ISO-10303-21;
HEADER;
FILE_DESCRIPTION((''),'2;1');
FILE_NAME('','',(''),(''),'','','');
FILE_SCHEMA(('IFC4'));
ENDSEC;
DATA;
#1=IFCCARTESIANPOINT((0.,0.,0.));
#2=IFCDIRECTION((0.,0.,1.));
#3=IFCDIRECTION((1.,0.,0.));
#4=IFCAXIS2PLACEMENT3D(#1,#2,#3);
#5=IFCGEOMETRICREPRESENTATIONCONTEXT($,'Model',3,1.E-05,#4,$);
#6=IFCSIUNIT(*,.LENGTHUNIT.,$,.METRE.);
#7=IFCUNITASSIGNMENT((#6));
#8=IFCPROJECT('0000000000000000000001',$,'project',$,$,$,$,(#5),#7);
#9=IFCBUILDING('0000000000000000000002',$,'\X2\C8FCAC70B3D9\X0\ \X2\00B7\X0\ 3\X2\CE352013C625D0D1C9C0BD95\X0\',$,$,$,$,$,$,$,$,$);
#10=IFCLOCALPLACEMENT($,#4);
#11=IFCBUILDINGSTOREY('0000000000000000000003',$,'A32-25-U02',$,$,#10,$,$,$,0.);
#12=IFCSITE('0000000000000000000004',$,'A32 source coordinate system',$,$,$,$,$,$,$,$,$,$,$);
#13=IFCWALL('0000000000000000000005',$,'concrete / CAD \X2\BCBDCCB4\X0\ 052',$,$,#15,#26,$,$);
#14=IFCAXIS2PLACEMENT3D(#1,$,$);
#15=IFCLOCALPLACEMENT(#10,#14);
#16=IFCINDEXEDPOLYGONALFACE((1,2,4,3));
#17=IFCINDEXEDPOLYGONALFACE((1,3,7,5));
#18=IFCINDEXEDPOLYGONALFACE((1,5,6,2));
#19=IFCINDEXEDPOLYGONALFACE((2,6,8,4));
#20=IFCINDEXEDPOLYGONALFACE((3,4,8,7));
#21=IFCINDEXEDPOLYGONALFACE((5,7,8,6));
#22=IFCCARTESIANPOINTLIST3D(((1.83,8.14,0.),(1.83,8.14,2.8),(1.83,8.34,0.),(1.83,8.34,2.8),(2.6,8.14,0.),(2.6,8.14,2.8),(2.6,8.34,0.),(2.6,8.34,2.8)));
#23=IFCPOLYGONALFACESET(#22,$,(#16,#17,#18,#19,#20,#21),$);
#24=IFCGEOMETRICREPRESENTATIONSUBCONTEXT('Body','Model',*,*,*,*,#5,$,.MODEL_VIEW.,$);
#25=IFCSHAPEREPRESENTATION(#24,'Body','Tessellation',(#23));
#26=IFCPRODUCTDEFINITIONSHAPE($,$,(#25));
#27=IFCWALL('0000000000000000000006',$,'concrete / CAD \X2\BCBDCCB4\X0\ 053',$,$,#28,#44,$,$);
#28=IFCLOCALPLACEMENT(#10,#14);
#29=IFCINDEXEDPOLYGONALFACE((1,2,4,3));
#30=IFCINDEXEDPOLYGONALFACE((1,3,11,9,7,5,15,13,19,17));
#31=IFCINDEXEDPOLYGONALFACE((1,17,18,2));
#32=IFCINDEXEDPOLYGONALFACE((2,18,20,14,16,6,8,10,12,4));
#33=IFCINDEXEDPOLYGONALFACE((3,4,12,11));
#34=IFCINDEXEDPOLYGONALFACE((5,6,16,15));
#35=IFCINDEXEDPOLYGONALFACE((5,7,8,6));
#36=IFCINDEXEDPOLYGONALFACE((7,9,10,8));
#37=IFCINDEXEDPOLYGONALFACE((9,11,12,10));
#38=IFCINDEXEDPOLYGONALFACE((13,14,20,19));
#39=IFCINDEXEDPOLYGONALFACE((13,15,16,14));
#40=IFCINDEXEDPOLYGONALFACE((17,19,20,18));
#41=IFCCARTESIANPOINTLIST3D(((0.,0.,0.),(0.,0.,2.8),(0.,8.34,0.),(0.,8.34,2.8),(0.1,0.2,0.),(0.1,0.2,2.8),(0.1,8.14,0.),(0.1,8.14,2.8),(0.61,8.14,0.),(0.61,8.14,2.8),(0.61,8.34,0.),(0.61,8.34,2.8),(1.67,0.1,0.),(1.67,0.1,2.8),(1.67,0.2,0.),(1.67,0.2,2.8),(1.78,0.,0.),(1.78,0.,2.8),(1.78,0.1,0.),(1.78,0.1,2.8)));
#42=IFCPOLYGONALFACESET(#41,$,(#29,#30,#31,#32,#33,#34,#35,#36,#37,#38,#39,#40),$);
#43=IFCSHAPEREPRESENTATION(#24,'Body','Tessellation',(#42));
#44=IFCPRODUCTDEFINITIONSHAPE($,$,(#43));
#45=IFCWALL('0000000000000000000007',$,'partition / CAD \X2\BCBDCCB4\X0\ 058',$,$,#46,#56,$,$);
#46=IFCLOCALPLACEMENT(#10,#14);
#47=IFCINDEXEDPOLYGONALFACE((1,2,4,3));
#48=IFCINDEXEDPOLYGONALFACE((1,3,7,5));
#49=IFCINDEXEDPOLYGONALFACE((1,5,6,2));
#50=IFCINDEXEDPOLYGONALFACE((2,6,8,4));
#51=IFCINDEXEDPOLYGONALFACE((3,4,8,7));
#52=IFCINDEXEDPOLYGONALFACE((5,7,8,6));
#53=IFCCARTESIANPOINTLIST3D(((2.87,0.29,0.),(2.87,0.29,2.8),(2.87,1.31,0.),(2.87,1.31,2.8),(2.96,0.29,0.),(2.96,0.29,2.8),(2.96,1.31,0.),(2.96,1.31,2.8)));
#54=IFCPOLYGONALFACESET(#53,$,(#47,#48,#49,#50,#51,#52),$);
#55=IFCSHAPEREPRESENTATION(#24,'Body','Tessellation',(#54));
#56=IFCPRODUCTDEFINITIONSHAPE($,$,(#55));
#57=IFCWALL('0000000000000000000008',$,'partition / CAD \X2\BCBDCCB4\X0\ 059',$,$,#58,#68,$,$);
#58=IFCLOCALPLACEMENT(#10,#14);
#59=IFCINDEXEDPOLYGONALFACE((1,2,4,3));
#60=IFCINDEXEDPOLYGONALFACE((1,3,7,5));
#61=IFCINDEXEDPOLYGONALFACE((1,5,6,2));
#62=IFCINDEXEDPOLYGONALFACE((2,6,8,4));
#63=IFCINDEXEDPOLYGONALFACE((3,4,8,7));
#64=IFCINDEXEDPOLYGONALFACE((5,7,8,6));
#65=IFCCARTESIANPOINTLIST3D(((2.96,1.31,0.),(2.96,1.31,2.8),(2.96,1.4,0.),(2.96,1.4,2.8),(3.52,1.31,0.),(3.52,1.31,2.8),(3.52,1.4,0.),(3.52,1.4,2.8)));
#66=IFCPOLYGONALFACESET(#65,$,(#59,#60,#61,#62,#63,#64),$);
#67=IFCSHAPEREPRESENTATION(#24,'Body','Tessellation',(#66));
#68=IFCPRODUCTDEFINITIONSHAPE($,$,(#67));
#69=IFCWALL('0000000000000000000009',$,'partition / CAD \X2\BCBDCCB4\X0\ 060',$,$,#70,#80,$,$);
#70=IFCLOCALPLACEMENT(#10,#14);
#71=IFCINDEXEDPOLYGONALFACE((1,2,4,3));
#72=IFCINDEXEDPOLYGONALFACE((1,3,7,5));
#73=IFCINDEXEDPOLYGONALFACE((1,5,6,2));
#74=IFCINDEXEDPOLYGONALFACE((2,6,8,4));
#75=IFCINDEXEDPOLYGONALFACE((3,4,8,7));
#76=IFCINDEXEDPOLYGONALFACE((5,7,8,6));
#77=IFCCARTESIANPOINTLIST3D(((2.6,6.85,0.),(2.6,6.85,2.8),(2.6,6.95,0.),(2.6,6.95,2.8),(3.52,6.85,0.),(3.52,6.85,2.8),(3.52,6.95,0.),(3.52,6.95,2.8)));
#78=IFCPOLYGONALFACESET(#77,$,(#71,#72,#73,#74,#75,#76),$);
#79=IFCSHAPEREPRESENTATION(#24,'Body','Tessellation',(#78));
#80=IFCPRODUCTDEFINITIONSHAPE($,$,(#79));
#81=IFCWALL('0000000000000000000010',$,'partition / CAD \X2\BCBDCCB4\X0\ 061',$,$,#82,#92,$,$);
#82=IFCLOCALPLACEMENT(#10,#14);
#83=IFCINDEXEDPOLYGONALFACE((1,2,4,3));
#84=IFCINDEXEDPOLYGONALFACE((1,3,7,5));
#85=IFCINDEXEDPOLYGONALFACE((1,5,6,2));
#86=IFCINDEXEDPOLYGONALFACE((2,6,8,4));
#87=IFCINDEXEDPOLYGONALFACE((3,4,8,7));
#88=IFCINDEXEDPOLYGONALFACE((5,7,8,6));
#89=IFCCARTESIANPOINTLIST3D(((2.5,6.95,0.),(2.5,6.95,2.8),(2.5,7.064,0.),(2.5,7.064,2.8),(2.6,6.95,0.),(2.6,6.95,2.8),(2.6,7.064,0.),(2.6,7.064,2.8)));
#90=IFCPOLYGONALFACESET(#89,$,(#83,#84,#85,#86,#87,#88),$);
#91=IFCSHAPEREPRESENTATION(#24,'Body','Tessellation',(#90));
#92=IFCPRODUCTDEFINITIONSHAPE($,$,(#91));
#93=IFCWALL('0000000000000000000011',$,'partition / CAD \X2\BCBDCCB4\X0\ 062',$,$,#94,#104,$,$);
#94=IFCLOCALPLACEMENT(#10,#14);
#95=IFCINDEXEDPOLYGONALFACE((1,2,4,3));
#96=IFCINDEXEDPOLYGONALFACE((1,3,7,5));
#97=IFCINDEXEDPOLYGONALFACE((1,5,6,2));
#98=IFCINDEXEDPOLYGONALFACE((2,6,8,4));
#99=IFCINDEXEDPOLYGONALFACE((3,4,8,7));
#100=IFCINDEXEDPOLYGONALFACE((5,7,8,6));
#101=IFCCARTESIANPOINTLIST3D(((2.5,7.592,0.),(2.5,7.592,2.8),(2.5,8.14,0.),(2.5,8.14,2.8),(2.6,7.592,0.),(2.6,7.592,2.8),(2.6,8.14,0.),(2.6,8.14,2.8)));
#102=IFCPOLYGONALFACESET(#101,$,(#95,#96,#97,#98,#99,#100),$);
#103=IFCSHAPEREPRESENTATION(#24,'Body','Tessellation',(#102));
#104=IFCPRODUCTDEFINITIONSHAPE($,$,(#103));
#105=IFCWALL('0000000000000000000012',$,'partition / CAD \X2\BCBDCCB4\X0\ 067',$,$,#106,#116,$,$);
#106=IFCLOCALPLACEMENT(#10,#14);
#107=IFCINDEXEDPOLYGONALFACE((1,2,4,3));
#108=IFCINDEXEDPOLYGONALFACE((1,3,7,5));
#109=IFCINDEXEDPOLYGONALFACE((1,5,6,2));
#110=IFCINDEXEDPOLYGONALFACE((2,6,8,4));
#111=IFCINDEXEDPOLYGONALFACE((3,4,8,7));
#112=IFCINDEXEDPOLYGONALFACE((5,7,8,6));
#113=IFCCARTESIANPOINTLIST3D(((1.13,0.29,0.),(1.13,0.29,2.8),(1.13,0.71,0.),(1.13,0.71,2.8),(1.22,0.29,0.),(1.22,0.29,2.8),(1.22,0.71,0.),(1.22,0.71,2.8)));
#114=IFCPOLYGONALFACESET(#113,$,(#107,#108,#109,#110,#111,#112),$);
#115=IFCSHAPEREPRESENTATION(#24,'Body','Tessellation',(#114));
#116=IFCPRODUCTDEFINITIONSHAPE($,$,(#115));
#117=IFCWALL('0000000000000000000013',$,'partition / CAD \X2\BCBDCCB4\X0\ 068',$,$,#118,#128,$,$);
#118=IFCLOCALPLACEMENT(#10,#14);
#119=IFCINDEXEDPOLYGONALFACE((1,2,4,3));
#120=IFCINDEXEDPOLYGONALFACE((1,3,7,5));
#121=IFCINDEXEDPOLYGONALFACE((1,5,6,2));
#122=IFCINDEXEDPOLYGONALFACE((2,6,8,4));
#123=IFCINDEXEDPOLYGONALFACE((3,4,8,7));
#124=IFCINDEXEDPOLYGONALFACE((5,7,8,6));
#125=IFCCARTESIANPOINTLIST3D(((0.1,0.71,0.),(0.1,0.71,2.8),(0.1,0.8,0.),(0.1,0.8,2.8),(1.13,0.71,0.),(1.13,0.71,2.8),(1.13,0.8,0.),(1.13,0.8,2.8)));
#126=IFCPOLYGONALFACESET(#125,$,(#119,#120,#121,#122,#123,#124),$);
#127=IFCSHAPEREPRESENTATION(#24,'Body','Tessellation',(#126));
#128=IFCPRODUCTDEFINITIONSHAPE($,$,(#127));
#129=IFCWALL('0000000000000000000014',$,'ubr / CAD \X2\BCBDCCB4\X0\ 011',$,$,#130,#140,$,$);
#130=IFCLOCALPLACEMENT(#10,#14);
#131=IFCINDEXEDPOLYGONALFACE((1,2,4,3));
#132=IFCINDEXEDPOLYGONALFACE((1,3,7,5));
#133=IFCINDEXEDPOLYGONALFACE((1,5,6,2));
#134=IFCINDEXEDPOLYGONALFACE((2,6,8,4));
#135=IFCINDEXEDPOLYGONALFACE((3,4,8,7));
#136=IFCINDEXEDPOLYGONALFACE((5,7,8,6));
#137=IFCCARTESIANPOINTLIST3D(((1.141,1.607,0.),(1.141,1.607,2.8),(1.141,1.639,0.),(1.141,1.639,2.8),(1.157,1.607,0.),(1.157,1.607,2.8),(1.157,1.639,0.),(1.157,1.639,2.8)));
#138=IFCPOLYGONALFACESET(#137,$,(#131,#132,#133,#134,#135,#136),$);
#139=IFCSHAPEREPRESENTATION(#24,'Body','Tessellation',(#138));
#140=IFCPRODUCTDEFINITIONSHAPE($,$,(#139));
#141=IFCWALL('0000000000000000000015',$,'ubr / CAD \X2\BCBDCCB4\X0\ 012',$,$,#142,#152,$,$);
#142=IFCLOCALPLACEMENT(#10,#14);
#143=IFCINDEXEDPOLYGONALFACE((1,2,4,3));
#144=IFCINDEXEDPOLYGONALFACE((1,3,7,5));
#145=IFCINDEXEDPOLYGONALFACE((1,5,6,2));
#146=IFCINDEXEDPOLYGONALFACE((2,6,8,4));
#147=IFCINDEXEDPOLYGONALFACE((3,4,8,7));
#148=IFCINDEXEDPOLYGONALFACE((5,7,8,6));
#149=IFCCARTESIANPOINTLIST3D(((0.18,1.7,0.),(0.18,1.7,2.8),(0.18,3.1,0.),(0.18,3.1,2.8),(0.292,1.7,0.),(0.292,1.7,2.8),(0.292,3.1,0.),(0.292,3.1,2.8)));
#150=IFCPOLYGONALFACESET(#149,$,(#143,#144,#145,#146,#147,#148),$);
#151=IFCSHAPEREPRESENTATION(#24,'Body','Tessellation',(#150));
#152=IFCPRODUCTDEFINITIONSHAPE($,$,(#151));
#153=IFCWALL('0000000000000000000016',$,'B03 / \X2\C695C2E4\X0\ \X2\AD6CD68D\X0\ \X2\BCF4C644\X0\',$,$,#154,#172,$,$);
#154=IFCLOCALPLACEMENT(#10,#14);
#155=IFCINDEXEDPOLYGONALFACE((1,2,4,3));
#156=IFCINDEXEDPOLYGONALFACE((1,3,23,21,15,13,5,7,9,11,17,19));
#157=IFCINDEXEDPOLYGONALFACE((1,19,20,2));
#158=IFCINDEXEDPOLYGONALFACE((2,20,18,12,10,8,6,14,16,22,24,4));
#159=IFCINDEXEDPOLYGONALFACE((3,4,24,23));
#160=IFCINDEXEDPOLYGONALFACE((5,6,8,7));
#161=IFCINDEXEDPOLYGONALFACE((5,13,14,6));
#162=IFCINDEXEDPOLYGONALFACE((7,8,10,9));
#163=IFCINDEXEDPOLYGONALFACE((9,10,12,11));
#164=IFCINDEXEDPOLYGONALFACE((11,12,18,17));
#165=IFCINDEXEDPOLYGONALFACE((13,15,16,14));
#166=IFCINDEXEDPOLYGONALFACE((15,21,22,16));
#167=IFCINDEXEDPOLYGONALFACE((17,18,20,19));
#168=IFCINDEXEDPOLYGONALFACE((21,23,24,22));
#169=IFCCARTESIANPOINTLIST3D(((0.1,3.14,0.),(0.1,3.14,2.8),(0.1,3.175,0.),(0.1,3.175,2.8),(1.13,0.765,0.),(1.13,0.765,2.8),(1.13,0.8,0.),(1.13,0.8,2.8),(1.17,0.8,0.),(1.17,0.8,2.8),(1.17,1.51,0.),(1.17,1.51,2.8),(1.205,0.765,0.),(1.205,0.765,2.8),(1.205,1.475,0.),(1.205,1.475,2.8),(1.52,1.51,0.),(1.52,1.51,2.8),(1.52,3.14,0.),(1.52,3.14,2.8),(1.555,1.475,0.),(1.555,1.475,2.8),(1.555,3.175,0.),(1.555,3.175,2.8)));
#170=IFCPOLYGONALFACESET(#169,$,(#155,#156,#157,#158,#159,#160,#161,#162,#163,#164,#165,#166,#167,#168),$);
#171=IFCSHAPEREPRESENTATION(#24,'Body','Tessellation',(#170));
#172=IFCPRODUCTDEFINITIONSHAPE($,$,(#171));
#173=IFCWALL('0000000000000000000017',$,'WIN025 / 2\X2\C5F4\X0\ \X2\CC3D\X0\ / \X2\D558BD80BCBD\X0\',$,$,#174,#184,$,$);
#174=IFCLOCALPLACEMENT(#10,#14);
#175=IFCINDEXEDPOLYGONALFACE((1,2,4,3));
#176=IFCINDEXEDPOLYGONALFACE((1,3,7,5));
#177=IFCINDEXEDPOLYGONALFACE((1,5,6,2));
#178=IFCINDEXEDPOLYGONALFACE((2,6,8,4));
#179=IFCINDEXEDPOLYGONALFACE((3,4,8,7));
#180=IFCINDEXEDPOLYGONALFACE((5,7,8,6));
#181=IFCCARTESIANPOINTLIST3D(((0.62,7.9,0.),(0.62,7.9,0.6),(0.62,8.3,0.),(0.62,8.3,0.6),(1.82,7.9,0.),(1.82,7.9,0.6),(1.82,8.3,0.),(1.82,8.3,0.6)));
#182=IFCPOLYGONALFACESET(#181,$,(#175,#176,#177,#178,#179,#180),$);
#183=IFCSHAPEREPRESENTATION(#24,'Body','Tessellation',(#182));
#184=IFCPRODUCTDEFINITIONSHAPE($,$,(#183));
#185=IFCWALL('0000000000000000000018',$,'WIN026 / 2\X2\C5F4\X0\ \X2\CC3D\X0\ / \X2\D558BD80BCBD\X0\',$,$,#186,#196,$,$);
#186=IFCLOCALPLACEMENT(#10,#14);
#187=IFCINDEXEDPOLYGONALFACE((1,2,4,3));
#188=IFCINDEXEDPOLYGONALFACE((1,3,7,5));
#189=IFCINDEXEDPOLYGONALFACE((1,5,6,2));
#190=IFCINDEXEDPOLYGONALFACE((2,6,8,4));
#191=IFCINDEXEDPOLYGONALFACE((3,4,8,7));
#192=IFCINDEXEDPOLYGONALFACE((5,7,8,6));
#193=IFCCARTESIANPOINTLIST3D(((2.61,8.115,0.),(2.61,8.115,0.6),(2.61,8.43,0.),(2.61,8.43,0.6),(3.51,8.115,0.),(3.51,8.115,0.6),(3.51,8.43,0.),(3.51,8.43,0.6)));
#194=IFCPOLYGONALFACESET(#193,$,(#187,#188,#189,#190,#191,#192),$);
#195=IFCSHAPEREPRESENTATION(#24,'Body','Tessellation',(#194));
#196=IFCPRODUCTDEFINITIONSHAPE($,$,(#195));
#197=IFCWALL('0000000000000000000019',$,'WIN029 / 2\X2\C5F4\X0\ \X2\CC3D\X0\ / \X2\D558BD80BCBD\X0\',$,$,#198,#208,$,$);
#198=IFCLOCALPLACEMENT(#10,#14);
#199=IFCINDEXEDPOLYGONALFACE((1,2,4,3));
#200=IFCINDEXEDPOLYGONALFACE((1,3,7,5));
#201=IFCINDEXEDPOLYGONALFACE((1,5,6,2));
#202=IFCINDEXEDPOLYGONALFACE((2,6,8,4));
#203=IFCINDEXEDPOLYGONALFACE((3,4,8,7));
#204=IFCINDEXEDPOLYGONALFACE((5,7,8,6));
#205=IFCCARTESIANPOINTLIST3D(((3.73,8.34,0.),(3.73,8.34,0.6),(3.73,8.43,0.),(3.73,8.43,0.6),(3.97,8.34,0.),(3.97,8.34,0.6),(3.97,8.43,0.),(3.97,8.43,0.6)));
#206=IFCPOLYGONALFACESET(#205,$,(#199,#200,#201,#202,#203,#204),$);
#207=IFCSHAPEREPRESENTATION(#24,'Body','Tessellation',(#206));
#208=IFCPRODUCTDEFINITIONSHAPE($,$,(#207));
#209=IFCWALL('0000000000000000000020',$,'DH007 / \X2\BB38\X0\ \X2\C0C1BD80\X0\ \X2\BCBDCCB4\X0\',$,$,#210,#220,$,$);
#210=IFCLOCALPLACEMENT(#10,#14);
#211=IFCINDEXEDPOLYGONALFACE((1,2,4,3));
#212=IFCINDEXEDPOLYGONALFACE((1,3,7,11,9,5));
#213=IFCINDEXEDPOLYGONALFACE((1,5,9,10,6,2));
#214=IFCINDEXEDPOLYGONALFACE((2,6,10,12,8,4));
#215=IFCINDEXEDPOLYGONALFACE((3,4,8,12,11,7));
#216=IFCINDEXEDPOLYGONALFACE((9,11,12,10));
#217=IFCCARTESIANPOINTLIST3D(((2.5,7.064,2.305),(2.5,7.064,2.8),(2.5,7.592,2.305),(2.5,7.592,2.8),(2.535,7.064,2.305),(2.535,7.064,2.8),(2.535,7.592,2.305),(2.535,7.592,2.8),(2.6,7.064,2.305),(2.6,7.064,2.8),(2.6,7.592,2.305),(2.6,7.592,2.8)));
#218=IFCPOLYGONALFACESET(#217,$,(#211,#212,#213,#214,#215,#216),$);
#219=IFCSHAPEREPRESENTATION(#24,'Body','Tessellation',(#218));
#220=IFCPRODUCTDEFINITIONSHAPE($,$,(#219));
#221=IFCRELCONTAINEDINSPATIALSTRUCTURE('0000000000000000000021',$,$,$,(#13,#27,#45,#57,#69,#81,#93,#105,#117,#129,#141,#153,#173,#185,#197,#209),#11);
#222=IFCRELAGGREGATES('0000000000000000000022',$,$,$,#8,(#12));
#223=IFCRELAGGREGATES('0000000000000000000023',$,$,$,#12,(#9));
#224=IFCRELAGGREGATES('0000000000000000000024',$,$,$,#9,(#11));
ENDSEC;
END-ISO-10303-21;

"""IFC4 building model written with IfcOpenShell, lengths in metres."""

from ifc_helpers import new_model, si_unit, frame, origin, origin_with_axes, place, context, subcontext, project, spatial, polyline, outline, extrude, element, save


model = new_model("IFC4")

# Units and contexts
model_context = context("Model", 3, precision=1e-05, world=origin_with_axes())
body_context = subcontext(model_context, "Body", "Model", "MODEL_VIEW")
ifc_project = project(units=[si_unit("LENGTHUNIT", "METRE")], contexts=[model_context])

# Site, building, storey
site = spatial("IfcSite", under=ifc_project, Name="A32 source coordinate system")
building = spatial("IfcBuilding", under=site, Name="주거동 · 3층–옥탑지붕")
storey_placement = place(None, origin_with_axes())
storey = spatial("IfcBuildingStorey", under=building, at=storey_placement, Name="A32-25-U02", Elevation=0.0)

# Walls
wall_1_placement = place(storey_placement, origin_with_axes())
element("IfcWall", 1, at=wall_1_placement, inside=storey, Name="concrete / CAD 벽체 052", context=body_context, shape_type="SweptSolid", body=[
    extrude(outline(polyline([(2.6, 8.14), (1.83, 8.14), (1.83, 8.34), (2.6, 8.34), (2.6, 8.14)])), origin(), (0.0, 0.0, 1.0), 2.8),
])
wall_2_placement = place(storey_placement, origin_with_axes())
element("IfcWall", 2, at=wall_2_placement, inside=storey, Name="concrete / CAD 벽체 053", context=body_context, shape_type="SweptSolid", body=[
    extrude(outline(polyline([(0.61, 8.34), (0.61, 8.14), (0.1, 8.14), (0.1, 0.2), (1.67, 0.2), (1.67, 0.1), (1.78, 0.1), (1.78, 0.0), (0.0, 0.0), (0.0, 8.34), (0.0, 8.34), (-0.35, 8.34), (-0.35, 8.34), (0.61, 8.34)])), origin(), (0.0, 0.0, 1.0), 2.8),
])
wall_3_placement = place(storey_placement, origin_with_axes())
element("IfcWall", 3, at=wall_3_placement, inside=storey, Name="partition / CAD 벽체 058", context=body_context, shape_type="SweptSolid", body=[
    extrude(outline(polyline([(2.96, 1.31), (2.96, 0.29), (2.87, 0.29), (2.87, 1.31), (2.96, 1.31)])), origin(), (0.0, 0.0, 1.0), 2.8),
])
wall_4_placement = place(storey_placement, origin_with_axes())
element("IfcWall", 4, at=wall_4_placement, inside=storey, Name="partition / CAD 벽체 059", context=body_context, shape_type="SweptSolid", body=[
    extrude(outline(polyline([(3.52, 1.31), (2.96, 1.31), (2.96, 1.4), (3.52, 1.4), (3.52, 1.31)])), origin(), (0.0, 0.0, 1.0), 2.8),
])
wall_5_placement = place(storey_placement, origin_with_axes())
element("IfcWall", 5, at=wall_5_placement, inside=storey, Name="partition / CAD 벽체 060", context=body_context, shape_type="SweptSolid", body=[
    extrude(outline(polyline([(3.52, 6.85), (2.6, 6.85), (2.6, 6.95), (3.52, 6.95), (3.52, 6.85)])), origin(), (0.0, 0.0, 1.0), 2.8),
])
wall_6_placement = place(storey_placement, origin_with_axes())
element("IfcWall", 6, at=wall_6_placement, inside=storey, Name="partition / CAD 벽체 061", context=body_context, shape_type="SweptSolid", body=[
    extrude(outline(polyline([(2.6, 7.064), (2.6, 6.95), (2.5, 6.95), (2.5, 7.064), (2.6, 7.064)])), origin(), (0.0, 0.0, 1.0), 2.8),
])
wall_7_placement = place(storey_placement, origin_with_axes())
element("IfcWall", 7, at=wall_7_placement, inside=storey, Name="partition / CAD 벽체 062", context=body_context, shape_type="SweptSolid", body=[
    extrude(outline(polyline([(2.5, 7.592), (2.5, 8.14), (2.6, 8.14), (2.6, 7.592), (2.5, 7.592)])), origin(), (0.0, 0.0, 1.0), 2.8),
])
wall_8_placement = place(storey_placement, origin_with_axes())
element("IfcWall", 8, at=wall_8_placement, inside=storey, Name="partition / CAD 벽체 067", context=body_context, shape_type="SweptSolid", body=[
    extrude(outline(polyline([(1.22, 0.71), (1.22, 0.29), (1.13, 0.29), (1.13, 0.71), (1.22, 0.71)])), origin(), (0.0, 0.0, 1.0), 2.8),
])
wall_9_placement = place(storey_placement, origin_with_axes())
element("IfcWall", 9, at=wall_9_placement, inside=storey, Name="partition / CAD 벽체 068", context=body_context, shape_type="SweptSolid", body=[
    extrude(outline(polyline([(1.13, 0.8), (1.13, 0.71), (0.1, 0.71), (0.1, 0.8), (1.13, 0.8)])), origin(), (0.0, 0.0, 1.0), 2.8),
])
wall_10_placement = place(storey_placement, origin_with_axes())
element("IfcWall", 10, at=wall_10_placement, inside=storey, Name="ubr / CAD 벽체 011", context=body_context, shape_type="SweptSolid", body=[
    extrude(outline(polyline([(1.141, 1.607), (1.141, 1.639), (1.157, 1.639), (1.157, 1.607), (1.141, 1.607)])), origin(), (0.0, 0.0, 1.0), 2.8),
])
wall_11_placement = place(storey_placement, origin_with_axes())
element("IfcWall", 11, at=wall_11_placement, inside=storey, Name="ubr / CAD 벽체 012", context=body_context, shape_type="SweptSolid", body=[
    extrude(outline(polyline([(0.18, 1.7), (0.18, 3.1), (0.292, 3.1), (0.292, 1.7), (0.18, 1.7)])), origin(), (0.0, 0.0, 1.0), 2.8),
])
wall_12_placement = place(storey_placement, origin_with_axes())
element("IfcWall", 12, at=wall_12_placement, inside=storey, Name="B03 / 욕실 구획 보완", context=body_context, shape_type="SweptSolid", body=[
    extrude(outline(polyline([(1.13, 0.765), (1.13, 0.8), (1.17, 0.8), (1.17, 1.51), (1.52, 1.51), (1.52, 3.14), (0.1, 3.14), (0.1, 3.175), (1.555, 3.175), (1.555, 1.475), (1.205, 1.475), (1.205, 0.765), (1.13, 0.765)])), origin(), (0.0, 0.0, 1.0), 2.8),
])
wall_13_placement = place(storey_placement, origin_with_axes())
element("IfcWall", 13, at=wall_13_placement, inside=storey, Name="WIN025 / 2열 창 / 하부벽", context=body_context, shape_type="SweptSolid", body=[
    extrude(outline(polyline([(1.82, 8.3), (1.82, 7.9), (0.62, 7.9), (0.62, 8.3), (1.82, 8.3)])), origin(), (0.0, 0.0, 1.0), 0.6),
])
wall_14_placement = place(storey_placement, origin_with_axes())
element("IfcWall", 14, at=wall_14_placement, inside=storey, Name="WIN026 / 2열 창 / 하부벽", context=body_context, shape_type="SweptSolid", body=[
    extrude(outline(polyline([(3.51, 8.43), (3.51, 8.115), (2.61, 8.115), (2.61, 8.43), (3.51, 8.43)])), origin(), (0.0, 0.0, 1.0), 0.6),
])
wall_15_placement = place(storey_placement, origin_with_axes())
element("IfcWall", 15, at=wall_15_placement, inside=storey, Name="WIN029 / 2열 창 / 하부벽", context=body_context, shape_type="SweptSolid", body=[
    extrude(outline(polyline([(3.97, 8.43), (3.97, 8.34), (3.73, 8.34), (3.73, 8.43), (3.97, 8.43)])), origin(), (0.0, 0.0, 1.0), 0.6),
])
wall_16_placement = place(storey_placement, origin_with_axes())
element("IfcWall", 16, at=wall_16_placement, inside=storey, Name="DH007 / 문 상부 벽체", context=body_context, shape_type="SweptSolid", body=[
    extrude(outline(polyline([(2.5, 7.592), (2.535, 7.592), (2.6, 7.592), (2.6, 7.064), (2.535, 7.064), (2.5, 7.064), (2.5, 7.592)])), frame((0.0, 0.0, 2.305)), (0.0, 0.0, 1.0), 0.495),
])

save(model, "model.ifc")
